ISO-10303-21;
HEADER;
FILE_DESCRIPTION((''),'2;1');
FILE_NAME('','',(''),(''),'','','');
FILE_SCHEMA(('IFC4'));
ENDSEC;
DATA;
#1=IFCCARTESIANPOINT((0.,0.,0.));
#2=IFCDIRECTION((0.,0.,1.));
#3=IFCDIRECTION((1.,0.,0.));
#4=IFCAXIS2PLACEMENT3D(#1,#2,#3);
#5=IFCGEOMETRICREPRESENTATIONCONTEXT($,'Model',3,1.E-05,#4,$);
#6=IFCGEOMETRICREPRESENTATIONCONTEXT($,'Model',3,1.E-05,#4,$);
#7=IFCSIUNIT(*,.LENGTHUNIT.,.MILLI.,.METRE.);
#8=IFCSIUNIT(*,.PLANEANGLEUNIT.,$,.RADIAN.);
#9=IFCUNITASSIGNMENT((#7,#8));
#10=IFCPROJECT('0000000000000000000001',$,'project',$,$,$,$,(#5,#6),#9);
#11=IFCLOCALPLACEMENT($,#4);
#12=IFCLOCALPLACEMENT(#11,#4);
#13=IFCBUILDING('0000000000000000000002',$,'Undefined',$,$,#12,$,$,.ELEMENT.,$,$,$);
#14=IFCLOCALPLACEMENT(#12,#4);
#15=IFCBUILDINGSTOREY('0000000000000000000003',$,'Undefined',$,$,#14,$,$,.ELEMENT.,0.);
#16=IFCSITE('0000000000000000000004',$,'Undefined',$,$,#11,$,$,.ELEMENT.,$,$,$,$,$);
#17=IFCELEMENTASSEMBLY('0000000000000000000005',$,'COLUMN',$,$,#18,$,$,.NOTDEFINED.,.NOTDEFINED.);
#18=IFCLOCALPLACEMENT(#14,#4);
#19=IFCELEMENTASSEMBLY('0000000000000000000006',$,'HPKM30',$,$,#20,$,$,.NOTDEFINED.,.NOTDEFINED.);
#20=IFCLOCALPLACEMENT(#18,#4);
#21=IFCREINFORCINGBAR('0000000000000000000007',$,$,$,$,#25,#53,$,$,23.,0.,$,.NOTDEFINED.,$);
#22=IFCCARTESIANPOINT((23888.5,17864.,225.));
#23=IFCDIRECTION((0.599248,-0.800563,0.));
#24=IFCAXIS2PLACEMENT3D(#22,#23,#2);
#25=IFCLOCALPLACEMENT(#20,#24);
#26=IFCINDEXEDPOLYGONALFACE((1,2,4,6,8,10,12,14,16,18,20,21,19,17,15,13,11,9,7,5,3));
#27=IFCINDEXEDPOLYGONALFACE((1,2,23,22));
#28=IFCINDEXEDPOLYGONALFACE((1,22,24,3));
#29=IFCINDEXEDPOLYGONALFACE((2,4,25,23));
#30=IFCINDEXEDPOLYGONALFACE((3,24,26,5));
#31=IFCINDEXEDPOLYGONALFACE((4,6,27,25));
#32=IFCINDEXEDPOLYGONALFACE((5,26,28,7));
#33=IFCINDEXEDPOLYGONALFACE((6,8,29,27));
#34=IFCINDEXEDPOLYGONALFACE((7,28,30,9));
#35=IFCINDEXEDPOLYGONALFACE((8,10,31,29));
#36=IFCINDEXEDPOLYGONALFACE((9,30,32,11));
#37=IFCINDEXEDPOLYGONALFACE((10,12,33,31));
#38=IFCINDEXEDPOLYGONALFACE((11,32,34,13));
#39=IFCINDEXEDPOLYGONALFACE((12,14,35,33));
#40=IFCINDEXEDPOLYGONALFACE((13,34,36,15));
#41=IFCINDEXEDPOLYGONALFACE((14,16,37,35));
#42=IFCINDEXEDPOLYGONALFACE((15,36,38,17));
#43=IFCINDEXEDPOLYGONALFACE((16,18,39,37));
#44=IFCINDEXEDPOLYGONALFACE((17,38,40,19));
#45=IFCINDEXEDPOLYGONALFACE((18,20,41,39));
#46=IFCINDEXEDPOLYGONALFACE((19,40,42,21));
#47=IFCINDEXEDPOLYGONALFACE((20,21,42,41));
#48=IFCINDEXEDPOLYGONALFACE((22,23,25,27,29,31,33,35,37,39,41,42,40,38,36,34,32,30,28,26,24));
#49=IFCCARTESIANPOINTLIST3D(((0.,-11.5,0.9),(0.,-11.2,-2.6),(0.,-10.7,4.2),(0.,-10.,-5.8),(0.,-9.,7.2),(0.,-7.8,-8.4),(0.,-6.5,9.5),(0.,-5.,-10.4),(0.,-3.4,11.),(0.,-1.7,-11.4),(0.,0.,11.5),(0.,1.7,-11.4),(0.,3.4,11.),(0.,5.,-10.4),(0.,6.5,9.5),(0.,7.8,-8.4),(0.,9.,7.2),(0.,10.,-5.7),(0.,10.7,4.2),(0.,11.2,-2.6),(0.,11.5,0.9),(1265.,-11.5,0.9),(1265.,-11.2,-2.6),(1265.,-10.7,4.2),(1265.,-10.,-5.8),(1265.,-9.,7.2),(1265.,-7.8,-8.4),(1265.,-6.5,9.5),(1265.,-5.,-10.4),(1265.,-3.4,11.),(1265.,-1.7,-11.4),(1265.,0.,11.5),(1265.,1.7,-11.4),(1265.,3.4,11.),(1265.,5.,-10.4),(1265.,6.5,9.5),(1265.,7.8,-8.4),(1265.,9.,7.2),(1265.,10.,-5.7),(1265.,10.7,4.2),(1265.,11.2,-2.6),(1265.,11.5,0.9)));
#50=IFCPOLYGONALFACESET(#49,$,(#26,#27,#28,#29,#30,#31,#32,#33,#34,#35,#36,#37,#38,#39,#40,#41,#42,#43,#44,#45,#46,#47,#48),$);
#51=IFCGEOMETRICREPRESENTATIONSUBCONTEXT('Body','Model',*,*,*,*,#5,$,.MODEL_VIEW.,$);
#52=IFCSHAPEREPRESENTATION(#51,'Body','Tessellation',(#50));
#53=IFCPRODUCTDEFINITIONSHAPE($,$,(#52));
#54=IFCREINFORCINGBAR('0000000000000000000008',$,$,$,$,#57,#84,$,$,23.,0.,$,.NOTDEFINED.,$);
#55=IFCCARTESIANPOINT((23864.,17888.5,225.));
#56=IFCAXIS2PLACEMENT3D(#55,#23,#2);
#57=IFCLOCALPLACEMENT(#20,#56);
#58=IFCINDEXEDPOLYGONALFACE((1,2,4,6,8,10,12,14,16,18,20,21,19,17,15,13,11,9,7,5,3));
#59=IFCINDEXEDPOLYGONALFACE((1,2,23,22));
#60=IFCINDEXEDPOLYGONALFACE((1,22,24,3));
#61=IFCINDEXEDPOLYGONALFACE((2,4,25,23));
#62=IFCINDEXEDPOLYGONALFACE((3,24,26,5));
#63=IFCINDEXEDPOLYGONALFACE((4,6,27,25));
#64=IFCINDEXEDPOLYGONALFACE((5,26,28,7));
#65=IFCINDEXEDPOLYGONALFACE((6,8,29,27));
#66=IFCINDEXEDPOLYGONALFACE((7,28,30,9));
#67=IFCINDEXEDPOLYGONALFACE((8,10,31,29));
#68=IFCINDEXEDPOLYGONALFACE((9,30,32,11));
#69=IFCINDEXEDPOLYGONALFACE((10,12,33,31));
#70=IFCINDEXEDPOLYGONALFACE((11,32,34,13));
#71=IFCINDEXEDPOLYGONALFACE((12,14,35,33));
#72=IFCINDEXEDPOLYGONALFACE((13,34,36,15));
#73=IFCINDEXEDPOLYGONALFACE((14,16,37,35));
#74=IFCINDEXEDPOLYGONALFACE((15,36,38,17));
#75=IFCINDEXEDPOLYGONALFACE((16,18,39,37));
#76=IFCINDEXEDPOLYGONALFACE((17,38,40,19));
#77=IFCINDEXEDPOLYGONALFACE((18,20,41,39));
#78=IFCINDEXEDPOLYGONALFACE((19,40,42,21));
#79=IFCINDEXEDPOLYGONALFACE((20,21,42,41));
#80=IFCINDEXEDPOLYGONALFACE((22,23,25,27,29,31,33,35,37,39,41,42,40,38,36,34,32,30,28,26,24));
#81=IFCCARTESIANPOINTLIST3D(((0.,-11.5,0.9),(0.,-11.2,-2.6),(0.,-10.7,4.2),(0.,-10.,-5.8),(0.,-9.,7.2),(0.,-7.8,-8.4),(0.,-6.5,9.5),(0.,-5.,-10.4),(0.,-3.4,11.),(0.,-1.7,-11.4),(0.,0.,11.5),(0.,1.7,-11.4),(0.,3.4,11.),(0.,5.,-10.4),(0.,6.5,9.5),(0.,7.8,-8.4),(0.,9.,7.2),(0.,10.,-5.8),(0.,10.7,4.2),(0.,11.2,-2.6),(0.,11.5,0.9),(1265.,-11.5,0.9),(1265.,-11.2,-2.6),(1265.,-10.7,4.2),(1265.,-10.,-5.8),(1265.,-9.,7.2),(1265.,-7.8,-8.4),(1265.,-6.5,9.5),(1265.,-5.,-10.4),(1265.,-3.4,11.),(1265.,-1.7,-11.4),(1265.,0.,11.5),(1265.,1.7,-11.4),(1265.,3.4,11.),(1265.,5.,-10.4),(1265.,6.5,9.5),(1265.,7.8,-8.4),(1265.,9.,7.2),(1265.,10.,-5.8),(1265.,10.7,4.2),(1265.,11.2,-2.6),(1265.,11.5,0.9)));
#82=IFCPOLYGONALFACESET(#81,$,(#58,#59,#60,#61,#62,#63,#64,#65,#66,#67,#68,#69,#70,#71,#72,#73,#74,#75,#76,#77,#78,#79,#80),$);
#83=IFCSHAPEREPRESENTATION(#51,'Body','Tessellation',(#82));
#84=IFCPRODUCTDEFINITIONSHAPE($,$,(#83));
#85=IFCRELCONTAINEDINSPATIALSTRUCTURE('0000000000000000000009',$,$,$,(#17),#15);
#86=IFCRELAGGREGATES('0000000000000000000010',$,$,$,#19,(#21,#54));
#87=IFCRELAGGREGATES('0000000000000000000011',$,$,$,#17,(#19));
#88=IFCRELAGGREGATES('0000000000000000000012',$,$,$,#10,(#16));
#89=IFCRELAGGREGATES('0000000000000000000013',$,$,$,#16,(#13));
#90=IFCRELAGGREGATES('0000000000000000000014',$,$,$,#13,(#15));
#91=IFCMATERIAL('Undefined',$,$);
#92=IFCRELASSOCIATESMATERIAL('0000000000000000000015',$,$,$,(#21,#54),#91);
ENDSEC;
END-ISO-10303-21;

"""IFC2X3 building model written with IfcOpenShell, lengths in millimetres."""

from ifc_helpers import new_model, entity, si_unit, frame, origin_with_axes, place, context, subcontext, project, spatial, source, transform, mapped, material, element, aggregate, save


model = new_model("IFC2X3")

# Units and contexts
model_context_1 = context("Model", 3, precision=1e-05, world=origin_with_axes())
model_context_2 = context("Model", 3, precision=1e-05, world=origin_with_axes())
body_context = subcontext(model_context_1, "Body", "Model", "MODEL_VIEW")
ifc_project = project(units=[si_unit("LENGTHUNIT", "METRE", prefix="MILLI"), si_unit("PLANEANGLEUNIT", "RADIAN")], contexts=[model_context_1, model_context_2])

# Site, building, storey
site_placement = place(None, origin_with_axes())
site = spatial("IfcSite", under=ifc_project, at=site_placement, Name="Undefined", CompositionType="ELEMENT")
building_placement = place(site_placement, origin_with_axes())
building = spatial("IfcBuilding", under=site, at=building_placement, Name="Undefined", CompositionType="ELEMENT")
storey_placement = place(building_placement, origin_with_axes())
storey = spatial("IfcBuildingStorey", under=building, at=storey_placement, Name="Undefined", CompositionType="ELEMENT", Elevation=0.0)

# Element assemblies
assembly_1_placement = place(storey_placement, origin_with_axes())
assembly_1 = element("IfcElementAssembly", 1, at=assembly_1_placement, inside=storey, Name="COLUMN", AssemblyPlace="NOTDEFINED", PredefinedType="NOTDEFINED")
assembly_2_placement = place(assembly_1_placement, origin_with_axes())
assembly_2 = element("IfcElementAssembly", 2, at=assembly_2_placement, Name="HPKM30", AssemblyPlace="NOTDEFINED", PredefinedType="NOTDEFINED")
ifc_material_1 = material(Name="Undefined")

# Reinforcing bars
shared_shape_1 = source(origin_with_axes(), body_context, "Body", "AdvancedSweptSolid", [
    entity("IfcSweptDiskSolid", entity("IfcTrimmedCurve", entity("IfcLine", entity("IfcCartesianPoint", [0.0, 0.0, 0.0]), entity("IfcVector", entity("IfcDirection", [1.0, 0.0, 0.0]), 1.0)), [entity("IfcParameterValue", 0.0)], [entity("IfcParameterValue", 1265.0)], True, "PARAMETER"), 11.5, None, 0.0, 1265.0),
])
reinforcing_bar_1_placement = place(assembly_2_placement, frame((23888.5, 17864.0, 225.0), z_axis=(0.599248, -0.800563, 0.0), x_axis=(0.0, 0.0, 1.0)))
reinforcing_bar_1 = element("IfcReinforcingBar", 3, at=reinforcing_bar_1_placement, material=ifc_material_1, BarRole="NOTDEFINED", CrossSectionArea=0.0, NominalDiameter=23.0, context=body_context, shape_type="MappedRepresentation", body=[
    mapped(shared_shape_1, transform((0.0, 0.0, 0.0))),
])
shared_shape_2 = source(origin_with_axes(), body_context, "Body", "AdvancedSweptSolid", [
    entity("IfcSweptDiskSolid", entity("IfcTrimmedCurve", entity("IfcLine", entity("IfcCartesianPoint", [0.0, 0.0, 0.0]), entity("IfcVector", entity("IfcDirection", [1.0, 0.0, 0.0]), 1.0)), [entity("IfcParameterValue", 0.0)], [entity("IfcParameterValue", 1265.0)], True, "PARAMETER"), 11.5, None, 0.0, 1265.0),
])
reinforcing_bar_2_placement = place(assembly_2_placement, frame((23864.0, 17888.5, 225.0), z_axis=(0.599248, -0.800563, 0.0), x_axis=(0.0, 0.0, 1.0)))
reinforcing_bar_2 = element("IfcReinforcingBar", 4, at=reinforcing_bar_2_placement, material=ifc_material_1, BarRole="NOTDEFINED", CrossSectionArea=0.0, NominalDiameter=23.0, context=body_context, shape_type="MappedRepresentation", body=[
    mapped(shared_shape_2, transform((0.0, 0.0, 0.0))),
])
aggregate(assembly_2, [reinforcing_bar_1, reinforcing_bar_2])
aggregate(assembly_1, [assembly_2])

save(model, "model.ifc")
